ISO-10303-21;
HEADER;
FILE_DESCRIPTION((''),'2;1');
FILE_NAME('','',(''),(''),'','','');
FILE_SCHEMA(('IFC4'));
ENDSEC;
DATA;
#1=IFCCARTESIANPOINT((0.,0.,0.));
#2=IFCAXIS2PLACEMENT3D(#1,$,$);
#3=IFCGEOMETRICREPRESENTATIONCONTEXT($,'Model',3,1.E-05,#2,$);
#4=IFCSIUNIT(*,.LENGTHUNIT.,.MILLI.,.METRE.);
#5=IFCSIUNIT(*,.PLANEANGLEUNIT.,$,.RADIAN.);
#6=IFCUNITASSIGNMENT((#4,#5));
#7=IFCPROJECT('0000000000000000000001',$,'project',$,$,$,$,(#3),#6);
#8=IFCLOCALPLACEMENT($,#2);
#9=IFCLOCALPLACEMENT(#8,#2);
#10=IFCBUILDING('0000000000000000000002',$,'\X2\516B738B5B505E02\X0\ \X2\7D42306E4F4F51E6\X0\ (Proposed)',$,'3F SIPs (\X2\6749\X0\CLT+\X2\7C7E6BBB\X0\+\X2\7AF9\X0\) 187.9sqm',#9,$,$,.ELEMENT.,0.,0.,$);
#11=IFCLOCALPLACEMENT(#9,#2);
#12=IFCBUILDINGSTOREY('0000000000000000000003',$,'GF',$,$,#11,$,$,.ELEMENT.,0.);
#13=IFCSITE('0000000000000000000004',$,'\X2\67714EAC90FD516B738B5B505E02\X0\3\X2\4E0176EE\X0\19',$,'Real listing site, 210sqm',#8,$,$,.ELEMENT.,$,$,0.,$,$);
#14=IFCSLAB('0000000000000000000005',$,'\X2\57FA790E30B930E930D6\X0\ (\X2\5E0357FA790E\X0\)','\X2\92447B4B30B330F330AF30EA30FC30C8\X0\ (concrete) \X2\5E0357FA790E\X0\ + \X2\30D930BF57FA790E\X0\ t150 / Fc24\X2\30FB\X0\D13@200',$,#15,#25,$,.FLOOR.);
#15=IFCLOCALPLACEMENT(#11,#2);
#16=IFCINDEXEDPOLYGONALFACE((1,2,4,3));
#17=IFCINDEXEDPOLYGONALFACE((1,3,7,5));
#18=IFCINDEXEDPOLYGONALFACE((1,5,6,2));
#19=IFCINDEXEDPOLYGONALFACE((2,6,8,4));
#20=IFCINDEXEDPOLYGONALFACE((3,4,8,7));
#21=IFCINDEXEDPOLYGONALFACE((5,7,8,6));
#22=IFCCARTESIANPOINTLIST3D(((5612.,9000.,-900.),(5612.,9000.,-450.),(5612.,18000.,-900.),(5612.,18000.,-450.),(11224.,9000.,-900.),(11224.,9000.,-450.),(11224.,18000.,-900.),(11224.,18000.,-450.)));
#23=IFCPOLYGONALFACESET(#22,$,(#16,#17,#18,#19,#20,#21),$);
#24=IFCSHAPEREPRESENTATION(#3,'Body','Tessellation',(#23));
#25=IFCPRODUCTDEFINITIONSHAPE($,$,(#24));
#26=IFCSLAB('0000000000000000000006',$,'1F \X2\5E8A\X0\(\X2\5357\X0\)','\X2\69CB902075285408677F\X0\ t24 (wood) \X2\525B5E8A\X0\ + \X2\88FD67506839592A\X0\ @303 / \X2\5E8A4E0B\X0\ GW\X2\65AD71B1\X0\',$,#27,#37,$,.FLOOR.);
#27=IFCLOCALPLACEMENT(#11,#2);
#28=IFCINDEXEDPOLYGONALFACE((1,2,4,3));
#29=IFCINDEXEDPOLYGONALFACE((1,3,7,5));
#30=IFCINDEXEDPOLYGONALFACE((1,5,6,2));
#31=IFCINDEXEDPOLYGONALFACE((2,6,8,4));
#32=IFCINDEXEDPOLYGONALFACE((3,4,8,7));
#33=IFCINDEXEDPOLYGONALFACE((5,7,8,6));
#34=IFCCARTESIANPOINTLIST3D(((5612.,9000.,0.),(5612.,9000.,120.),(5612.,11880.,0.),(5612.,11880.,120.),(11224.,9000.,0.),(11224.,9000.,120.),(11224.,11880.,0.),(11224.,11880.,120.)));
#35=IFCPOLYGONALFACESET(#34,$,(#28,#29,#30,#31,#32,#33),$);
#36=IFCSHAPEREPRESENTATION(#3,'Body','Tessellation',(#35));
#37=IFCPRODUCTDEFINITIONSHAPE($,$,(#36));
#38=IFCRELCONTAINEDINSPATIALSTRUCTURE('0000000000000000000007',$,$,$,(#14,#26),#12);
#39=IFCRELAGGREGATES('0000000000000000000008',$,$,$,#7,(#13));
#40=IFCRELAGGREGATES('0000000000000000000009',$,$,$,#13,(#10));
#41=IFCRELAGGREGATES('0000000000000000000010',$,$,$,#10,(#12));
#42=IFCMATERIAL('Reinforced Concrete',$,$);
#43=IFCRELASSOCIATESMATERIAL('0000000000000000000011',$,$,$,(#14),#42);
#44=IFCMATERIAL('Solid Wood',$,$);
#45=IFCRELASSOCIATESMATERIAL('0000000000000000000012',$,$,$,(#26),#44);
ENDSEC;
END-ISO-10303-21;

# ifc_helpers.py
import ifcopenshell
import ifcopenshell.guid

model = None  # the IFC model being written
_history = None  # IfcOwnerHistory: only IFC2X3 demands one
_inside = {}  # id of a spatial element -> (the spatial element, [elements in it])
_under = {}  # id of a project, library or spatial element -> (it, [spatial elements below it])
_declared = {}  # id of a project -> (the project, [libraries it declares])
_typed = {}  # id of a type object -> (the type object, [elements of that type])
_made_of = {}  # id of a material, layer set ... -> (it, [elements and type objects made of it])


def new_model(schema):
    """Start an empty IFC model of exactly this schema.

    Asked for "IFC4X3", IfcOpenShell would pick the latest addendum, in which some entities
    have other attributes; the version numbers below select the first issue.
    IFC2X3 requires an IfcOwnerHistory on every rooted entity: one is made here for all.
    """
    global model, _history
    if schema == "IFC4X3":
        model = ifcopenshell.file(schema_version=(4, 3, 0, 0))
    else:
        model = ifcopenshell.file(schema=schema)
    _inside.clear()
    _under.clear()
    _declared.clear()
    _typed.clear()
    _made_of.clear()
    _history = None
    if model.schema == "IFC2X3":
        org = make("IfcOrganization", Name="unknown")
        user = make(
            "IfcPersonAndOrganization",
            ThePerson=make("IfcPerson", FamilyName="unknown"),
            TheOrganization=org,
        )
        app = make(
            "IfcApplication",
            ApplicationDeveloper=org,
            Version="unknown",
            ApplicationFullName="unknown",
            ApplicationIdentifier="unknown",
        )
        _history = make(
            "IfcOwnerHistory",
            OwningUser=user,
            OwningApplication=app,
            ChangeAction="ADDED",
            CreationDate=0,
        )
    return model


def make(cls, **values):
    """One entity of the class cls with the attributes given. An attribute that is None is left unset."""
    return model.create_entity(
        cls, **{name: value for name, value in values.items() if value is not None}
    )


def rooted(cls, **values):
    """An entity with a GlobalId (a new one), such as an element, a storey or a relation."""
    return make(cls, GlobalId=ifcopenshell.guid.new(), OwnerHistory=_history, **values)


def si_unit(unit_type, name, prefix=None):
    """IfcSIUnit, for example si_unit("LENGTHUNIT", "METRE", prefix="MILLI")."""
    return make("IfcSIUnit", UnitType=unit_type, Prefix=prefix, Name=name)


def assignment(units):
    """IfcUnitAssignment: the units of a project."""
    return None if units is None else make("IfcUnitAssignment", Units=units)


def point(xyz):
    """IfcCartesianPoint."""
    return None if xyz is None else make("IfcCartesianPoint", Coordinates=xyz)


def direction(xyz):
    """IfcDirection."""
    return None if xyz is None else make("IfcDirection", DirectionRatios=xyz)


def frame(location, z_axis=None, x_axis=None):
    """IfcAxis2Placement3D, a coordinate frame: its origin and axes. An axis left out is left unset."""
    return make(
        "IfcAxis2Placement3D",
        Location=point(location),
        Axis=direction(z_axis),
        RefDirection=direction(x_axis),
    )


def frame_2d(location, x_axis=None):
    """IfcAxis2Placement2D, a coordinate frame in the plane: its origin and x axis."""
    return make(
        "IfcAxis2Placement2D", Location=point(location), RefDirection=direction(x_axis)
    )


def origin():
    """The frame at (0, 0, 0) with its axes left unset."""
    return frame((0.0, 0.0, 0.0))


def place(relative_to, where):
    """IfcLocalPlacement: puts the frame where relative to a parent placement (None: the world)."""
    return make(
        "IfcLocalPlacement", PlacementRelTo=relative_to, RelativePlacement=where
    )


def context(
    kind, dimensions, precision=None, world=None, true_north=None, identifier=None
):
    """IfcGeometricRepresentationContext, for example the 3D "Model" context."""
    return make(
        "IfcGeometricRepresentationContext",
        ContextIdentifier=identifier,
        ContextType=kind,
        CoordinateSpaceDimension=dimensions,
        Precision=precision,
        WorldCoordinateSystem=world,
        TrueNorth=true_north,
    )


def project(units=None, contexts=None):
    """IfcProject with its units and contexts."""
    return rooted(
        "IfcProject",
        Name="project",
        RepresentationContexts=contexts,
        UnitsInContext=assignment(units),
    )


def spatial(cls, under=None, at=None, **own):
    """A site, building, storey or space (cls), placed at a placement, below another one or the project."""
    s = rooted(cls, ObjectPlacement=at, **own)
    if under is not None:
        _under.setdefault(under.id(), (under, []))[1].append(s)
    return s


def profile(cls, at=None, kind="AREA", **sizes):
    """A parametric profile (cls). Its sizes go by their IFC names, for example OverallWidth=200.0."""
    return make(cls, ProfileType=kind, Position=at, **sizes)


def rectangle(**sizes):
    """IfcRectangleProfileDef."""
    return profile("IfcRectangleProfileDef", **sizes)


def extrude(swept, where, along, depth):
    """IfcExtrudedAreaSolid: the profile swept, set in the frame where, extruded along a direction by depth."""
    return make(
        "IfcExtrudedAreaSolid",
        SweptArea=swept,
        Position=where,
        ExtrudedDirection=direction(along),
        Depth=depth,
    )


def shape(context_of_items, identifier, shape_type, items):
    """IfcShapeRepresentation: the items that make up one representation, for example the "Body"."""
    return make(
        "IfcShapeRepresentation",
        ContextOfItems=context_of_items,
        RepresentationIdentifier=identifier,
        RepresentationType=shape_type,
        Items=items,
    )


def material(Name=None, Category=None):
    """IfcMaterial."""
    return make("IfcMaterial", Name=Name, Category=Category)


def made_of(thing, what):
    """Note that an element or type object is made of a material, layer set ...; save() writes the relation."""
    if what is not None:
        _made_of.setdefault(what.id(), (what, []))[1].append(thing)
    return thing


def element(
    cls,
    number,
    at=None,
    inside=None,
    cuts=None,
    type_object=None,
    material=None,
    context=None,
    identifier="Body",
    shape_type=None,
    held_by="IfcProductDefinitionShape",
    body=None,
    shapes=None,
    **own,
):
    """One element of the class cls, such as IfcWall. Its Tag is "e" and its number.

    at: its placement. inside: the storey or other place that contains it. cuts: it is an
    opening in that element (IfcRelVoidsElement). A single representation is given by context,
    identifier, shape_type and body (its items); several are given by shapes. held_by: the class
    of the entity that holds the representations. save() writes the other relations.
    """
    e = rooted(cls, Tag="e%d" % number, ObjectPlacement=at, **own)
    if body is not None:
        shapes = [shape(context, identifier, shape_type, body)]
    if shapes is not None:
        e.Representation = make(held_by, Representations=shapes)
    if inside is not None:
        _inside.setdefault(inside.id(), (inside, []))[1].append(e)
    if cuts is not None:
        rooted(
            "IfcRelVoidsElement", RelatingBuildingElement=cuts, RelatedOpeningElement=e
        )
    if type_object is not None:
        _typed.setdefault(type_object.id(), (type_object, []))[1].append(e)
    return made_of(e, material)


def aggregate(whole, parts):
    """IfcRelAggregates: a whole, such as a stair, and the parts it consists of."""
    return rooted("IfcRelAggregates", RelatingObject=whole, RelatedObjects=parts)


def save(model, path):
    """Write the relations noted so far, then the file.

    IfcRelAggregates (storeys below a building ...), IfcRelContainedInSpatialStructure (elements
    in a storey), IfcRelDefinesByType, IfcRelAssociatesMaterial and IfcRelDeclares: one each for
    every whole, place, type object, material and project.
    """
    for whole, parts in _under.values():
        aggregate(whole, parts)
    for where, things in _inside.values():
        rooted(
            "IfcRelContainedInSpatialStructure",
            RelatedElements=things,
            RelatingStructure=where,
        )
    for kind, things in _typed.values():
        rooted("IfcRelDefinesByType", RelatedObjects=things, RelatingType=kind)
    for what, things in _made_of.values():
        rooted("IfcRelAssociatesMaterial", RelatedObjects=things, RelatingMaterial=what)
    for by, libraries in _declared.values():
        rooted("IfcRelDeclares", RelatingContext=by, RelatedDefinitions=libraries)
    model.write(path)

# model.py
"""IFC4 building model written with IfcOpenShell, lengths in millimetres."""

from ifc_helpers import new_model, si_unit, frame, frame_2d, origin, place, context, project, spatial, rectangle, extrude, material, element, save


model = new_model("IFC4")

# Units and contexts
model_context = context("Model", 3, precision=1e-05, world=origin())
ifc_project = project(units=[si_unit("LENGTHUNIT", "METRE", prefix="MILLI"), si_unit("PLANEANGLEUNIT", "RADIAN")], contexts=[model_context])

# Site, building, storey
site_placement = place(None, origin())
site = spatial("IfcSite", under=ifc_project, at=site_placement, Name="東京都八王子市3丁目19", ObjectType="Real listing site, 210sqm", CompositionType="ELEMENT", RefElevation=0.0)
building_placement = place(site_placement, origin())
building = spatial("IfcBuilding", under=site, at=building_placement, Name="八王子市 終の住処 (Proposed)", ObjectType="3F SIPs (杉CLT+籾殻+竹) 187.9sqm", CompositionType="ELEMENT", ElevationOfRefHeight=0.0, ElevationOfTerrain=0.0)
storey_placement = place(building_placement, origin())
storey = spatial("IfcBuildingStorey", under=building, at=storey_placement, Name="GF", CompositionType="ELEMENT", Elevation=0.0)

# Slabs
ifc_material_1 = material(Name="Reinforced Concrete")
slab_1_placement = place(storey_placement, frame((2806.0, 4500.0, -450.0)))
element("IfcSlab", 1, at=slab_1_placement, inside=storey, material=ifc_material_1, Name="基礎スラブ (布基礎)", Description="鉄筋コンクリート (concrete) 布基礎 + ベタ基礎 t150 / Fc24・D13@200", PredefinedType="FLOOR", context=model_context, shape_type="SweptSolid", body=[
    extrude(rectangle(XDim=5612.0, YDim=9000.0, at=frame_2d((2806.0, 4500.0))), frame((2806.0, 4500.0, -450.0)), (0.0, 0.0, 1.0), 450.0),
])
ifc_material_2 = material(Name="Solid Wood")
slab_2_placement = place(storey_placement, frame((2806.0, 4500.0, 0.0)))
element("IfcSlab", 2, at=slab_2_placement, inside=storey, material=ifc_material_2, Name="1F 床(南)", Description="構造用合板 t24 (wood) 剛床 + 製材根太 @303 / 床下 GW断熱", PredefinedType="FLOOR", context=model_context, shape_type="SweptSolid", body=[
    extrude(rectangle(XDim=5612.0, YDim=2880.0, at=frame_2d((2806.0, 1440.0))), frame((2806.0, 4500.0, 0.0)), (0.0, 0.0, 1.0), 120.0),
])

save(model, "model.ifc")
